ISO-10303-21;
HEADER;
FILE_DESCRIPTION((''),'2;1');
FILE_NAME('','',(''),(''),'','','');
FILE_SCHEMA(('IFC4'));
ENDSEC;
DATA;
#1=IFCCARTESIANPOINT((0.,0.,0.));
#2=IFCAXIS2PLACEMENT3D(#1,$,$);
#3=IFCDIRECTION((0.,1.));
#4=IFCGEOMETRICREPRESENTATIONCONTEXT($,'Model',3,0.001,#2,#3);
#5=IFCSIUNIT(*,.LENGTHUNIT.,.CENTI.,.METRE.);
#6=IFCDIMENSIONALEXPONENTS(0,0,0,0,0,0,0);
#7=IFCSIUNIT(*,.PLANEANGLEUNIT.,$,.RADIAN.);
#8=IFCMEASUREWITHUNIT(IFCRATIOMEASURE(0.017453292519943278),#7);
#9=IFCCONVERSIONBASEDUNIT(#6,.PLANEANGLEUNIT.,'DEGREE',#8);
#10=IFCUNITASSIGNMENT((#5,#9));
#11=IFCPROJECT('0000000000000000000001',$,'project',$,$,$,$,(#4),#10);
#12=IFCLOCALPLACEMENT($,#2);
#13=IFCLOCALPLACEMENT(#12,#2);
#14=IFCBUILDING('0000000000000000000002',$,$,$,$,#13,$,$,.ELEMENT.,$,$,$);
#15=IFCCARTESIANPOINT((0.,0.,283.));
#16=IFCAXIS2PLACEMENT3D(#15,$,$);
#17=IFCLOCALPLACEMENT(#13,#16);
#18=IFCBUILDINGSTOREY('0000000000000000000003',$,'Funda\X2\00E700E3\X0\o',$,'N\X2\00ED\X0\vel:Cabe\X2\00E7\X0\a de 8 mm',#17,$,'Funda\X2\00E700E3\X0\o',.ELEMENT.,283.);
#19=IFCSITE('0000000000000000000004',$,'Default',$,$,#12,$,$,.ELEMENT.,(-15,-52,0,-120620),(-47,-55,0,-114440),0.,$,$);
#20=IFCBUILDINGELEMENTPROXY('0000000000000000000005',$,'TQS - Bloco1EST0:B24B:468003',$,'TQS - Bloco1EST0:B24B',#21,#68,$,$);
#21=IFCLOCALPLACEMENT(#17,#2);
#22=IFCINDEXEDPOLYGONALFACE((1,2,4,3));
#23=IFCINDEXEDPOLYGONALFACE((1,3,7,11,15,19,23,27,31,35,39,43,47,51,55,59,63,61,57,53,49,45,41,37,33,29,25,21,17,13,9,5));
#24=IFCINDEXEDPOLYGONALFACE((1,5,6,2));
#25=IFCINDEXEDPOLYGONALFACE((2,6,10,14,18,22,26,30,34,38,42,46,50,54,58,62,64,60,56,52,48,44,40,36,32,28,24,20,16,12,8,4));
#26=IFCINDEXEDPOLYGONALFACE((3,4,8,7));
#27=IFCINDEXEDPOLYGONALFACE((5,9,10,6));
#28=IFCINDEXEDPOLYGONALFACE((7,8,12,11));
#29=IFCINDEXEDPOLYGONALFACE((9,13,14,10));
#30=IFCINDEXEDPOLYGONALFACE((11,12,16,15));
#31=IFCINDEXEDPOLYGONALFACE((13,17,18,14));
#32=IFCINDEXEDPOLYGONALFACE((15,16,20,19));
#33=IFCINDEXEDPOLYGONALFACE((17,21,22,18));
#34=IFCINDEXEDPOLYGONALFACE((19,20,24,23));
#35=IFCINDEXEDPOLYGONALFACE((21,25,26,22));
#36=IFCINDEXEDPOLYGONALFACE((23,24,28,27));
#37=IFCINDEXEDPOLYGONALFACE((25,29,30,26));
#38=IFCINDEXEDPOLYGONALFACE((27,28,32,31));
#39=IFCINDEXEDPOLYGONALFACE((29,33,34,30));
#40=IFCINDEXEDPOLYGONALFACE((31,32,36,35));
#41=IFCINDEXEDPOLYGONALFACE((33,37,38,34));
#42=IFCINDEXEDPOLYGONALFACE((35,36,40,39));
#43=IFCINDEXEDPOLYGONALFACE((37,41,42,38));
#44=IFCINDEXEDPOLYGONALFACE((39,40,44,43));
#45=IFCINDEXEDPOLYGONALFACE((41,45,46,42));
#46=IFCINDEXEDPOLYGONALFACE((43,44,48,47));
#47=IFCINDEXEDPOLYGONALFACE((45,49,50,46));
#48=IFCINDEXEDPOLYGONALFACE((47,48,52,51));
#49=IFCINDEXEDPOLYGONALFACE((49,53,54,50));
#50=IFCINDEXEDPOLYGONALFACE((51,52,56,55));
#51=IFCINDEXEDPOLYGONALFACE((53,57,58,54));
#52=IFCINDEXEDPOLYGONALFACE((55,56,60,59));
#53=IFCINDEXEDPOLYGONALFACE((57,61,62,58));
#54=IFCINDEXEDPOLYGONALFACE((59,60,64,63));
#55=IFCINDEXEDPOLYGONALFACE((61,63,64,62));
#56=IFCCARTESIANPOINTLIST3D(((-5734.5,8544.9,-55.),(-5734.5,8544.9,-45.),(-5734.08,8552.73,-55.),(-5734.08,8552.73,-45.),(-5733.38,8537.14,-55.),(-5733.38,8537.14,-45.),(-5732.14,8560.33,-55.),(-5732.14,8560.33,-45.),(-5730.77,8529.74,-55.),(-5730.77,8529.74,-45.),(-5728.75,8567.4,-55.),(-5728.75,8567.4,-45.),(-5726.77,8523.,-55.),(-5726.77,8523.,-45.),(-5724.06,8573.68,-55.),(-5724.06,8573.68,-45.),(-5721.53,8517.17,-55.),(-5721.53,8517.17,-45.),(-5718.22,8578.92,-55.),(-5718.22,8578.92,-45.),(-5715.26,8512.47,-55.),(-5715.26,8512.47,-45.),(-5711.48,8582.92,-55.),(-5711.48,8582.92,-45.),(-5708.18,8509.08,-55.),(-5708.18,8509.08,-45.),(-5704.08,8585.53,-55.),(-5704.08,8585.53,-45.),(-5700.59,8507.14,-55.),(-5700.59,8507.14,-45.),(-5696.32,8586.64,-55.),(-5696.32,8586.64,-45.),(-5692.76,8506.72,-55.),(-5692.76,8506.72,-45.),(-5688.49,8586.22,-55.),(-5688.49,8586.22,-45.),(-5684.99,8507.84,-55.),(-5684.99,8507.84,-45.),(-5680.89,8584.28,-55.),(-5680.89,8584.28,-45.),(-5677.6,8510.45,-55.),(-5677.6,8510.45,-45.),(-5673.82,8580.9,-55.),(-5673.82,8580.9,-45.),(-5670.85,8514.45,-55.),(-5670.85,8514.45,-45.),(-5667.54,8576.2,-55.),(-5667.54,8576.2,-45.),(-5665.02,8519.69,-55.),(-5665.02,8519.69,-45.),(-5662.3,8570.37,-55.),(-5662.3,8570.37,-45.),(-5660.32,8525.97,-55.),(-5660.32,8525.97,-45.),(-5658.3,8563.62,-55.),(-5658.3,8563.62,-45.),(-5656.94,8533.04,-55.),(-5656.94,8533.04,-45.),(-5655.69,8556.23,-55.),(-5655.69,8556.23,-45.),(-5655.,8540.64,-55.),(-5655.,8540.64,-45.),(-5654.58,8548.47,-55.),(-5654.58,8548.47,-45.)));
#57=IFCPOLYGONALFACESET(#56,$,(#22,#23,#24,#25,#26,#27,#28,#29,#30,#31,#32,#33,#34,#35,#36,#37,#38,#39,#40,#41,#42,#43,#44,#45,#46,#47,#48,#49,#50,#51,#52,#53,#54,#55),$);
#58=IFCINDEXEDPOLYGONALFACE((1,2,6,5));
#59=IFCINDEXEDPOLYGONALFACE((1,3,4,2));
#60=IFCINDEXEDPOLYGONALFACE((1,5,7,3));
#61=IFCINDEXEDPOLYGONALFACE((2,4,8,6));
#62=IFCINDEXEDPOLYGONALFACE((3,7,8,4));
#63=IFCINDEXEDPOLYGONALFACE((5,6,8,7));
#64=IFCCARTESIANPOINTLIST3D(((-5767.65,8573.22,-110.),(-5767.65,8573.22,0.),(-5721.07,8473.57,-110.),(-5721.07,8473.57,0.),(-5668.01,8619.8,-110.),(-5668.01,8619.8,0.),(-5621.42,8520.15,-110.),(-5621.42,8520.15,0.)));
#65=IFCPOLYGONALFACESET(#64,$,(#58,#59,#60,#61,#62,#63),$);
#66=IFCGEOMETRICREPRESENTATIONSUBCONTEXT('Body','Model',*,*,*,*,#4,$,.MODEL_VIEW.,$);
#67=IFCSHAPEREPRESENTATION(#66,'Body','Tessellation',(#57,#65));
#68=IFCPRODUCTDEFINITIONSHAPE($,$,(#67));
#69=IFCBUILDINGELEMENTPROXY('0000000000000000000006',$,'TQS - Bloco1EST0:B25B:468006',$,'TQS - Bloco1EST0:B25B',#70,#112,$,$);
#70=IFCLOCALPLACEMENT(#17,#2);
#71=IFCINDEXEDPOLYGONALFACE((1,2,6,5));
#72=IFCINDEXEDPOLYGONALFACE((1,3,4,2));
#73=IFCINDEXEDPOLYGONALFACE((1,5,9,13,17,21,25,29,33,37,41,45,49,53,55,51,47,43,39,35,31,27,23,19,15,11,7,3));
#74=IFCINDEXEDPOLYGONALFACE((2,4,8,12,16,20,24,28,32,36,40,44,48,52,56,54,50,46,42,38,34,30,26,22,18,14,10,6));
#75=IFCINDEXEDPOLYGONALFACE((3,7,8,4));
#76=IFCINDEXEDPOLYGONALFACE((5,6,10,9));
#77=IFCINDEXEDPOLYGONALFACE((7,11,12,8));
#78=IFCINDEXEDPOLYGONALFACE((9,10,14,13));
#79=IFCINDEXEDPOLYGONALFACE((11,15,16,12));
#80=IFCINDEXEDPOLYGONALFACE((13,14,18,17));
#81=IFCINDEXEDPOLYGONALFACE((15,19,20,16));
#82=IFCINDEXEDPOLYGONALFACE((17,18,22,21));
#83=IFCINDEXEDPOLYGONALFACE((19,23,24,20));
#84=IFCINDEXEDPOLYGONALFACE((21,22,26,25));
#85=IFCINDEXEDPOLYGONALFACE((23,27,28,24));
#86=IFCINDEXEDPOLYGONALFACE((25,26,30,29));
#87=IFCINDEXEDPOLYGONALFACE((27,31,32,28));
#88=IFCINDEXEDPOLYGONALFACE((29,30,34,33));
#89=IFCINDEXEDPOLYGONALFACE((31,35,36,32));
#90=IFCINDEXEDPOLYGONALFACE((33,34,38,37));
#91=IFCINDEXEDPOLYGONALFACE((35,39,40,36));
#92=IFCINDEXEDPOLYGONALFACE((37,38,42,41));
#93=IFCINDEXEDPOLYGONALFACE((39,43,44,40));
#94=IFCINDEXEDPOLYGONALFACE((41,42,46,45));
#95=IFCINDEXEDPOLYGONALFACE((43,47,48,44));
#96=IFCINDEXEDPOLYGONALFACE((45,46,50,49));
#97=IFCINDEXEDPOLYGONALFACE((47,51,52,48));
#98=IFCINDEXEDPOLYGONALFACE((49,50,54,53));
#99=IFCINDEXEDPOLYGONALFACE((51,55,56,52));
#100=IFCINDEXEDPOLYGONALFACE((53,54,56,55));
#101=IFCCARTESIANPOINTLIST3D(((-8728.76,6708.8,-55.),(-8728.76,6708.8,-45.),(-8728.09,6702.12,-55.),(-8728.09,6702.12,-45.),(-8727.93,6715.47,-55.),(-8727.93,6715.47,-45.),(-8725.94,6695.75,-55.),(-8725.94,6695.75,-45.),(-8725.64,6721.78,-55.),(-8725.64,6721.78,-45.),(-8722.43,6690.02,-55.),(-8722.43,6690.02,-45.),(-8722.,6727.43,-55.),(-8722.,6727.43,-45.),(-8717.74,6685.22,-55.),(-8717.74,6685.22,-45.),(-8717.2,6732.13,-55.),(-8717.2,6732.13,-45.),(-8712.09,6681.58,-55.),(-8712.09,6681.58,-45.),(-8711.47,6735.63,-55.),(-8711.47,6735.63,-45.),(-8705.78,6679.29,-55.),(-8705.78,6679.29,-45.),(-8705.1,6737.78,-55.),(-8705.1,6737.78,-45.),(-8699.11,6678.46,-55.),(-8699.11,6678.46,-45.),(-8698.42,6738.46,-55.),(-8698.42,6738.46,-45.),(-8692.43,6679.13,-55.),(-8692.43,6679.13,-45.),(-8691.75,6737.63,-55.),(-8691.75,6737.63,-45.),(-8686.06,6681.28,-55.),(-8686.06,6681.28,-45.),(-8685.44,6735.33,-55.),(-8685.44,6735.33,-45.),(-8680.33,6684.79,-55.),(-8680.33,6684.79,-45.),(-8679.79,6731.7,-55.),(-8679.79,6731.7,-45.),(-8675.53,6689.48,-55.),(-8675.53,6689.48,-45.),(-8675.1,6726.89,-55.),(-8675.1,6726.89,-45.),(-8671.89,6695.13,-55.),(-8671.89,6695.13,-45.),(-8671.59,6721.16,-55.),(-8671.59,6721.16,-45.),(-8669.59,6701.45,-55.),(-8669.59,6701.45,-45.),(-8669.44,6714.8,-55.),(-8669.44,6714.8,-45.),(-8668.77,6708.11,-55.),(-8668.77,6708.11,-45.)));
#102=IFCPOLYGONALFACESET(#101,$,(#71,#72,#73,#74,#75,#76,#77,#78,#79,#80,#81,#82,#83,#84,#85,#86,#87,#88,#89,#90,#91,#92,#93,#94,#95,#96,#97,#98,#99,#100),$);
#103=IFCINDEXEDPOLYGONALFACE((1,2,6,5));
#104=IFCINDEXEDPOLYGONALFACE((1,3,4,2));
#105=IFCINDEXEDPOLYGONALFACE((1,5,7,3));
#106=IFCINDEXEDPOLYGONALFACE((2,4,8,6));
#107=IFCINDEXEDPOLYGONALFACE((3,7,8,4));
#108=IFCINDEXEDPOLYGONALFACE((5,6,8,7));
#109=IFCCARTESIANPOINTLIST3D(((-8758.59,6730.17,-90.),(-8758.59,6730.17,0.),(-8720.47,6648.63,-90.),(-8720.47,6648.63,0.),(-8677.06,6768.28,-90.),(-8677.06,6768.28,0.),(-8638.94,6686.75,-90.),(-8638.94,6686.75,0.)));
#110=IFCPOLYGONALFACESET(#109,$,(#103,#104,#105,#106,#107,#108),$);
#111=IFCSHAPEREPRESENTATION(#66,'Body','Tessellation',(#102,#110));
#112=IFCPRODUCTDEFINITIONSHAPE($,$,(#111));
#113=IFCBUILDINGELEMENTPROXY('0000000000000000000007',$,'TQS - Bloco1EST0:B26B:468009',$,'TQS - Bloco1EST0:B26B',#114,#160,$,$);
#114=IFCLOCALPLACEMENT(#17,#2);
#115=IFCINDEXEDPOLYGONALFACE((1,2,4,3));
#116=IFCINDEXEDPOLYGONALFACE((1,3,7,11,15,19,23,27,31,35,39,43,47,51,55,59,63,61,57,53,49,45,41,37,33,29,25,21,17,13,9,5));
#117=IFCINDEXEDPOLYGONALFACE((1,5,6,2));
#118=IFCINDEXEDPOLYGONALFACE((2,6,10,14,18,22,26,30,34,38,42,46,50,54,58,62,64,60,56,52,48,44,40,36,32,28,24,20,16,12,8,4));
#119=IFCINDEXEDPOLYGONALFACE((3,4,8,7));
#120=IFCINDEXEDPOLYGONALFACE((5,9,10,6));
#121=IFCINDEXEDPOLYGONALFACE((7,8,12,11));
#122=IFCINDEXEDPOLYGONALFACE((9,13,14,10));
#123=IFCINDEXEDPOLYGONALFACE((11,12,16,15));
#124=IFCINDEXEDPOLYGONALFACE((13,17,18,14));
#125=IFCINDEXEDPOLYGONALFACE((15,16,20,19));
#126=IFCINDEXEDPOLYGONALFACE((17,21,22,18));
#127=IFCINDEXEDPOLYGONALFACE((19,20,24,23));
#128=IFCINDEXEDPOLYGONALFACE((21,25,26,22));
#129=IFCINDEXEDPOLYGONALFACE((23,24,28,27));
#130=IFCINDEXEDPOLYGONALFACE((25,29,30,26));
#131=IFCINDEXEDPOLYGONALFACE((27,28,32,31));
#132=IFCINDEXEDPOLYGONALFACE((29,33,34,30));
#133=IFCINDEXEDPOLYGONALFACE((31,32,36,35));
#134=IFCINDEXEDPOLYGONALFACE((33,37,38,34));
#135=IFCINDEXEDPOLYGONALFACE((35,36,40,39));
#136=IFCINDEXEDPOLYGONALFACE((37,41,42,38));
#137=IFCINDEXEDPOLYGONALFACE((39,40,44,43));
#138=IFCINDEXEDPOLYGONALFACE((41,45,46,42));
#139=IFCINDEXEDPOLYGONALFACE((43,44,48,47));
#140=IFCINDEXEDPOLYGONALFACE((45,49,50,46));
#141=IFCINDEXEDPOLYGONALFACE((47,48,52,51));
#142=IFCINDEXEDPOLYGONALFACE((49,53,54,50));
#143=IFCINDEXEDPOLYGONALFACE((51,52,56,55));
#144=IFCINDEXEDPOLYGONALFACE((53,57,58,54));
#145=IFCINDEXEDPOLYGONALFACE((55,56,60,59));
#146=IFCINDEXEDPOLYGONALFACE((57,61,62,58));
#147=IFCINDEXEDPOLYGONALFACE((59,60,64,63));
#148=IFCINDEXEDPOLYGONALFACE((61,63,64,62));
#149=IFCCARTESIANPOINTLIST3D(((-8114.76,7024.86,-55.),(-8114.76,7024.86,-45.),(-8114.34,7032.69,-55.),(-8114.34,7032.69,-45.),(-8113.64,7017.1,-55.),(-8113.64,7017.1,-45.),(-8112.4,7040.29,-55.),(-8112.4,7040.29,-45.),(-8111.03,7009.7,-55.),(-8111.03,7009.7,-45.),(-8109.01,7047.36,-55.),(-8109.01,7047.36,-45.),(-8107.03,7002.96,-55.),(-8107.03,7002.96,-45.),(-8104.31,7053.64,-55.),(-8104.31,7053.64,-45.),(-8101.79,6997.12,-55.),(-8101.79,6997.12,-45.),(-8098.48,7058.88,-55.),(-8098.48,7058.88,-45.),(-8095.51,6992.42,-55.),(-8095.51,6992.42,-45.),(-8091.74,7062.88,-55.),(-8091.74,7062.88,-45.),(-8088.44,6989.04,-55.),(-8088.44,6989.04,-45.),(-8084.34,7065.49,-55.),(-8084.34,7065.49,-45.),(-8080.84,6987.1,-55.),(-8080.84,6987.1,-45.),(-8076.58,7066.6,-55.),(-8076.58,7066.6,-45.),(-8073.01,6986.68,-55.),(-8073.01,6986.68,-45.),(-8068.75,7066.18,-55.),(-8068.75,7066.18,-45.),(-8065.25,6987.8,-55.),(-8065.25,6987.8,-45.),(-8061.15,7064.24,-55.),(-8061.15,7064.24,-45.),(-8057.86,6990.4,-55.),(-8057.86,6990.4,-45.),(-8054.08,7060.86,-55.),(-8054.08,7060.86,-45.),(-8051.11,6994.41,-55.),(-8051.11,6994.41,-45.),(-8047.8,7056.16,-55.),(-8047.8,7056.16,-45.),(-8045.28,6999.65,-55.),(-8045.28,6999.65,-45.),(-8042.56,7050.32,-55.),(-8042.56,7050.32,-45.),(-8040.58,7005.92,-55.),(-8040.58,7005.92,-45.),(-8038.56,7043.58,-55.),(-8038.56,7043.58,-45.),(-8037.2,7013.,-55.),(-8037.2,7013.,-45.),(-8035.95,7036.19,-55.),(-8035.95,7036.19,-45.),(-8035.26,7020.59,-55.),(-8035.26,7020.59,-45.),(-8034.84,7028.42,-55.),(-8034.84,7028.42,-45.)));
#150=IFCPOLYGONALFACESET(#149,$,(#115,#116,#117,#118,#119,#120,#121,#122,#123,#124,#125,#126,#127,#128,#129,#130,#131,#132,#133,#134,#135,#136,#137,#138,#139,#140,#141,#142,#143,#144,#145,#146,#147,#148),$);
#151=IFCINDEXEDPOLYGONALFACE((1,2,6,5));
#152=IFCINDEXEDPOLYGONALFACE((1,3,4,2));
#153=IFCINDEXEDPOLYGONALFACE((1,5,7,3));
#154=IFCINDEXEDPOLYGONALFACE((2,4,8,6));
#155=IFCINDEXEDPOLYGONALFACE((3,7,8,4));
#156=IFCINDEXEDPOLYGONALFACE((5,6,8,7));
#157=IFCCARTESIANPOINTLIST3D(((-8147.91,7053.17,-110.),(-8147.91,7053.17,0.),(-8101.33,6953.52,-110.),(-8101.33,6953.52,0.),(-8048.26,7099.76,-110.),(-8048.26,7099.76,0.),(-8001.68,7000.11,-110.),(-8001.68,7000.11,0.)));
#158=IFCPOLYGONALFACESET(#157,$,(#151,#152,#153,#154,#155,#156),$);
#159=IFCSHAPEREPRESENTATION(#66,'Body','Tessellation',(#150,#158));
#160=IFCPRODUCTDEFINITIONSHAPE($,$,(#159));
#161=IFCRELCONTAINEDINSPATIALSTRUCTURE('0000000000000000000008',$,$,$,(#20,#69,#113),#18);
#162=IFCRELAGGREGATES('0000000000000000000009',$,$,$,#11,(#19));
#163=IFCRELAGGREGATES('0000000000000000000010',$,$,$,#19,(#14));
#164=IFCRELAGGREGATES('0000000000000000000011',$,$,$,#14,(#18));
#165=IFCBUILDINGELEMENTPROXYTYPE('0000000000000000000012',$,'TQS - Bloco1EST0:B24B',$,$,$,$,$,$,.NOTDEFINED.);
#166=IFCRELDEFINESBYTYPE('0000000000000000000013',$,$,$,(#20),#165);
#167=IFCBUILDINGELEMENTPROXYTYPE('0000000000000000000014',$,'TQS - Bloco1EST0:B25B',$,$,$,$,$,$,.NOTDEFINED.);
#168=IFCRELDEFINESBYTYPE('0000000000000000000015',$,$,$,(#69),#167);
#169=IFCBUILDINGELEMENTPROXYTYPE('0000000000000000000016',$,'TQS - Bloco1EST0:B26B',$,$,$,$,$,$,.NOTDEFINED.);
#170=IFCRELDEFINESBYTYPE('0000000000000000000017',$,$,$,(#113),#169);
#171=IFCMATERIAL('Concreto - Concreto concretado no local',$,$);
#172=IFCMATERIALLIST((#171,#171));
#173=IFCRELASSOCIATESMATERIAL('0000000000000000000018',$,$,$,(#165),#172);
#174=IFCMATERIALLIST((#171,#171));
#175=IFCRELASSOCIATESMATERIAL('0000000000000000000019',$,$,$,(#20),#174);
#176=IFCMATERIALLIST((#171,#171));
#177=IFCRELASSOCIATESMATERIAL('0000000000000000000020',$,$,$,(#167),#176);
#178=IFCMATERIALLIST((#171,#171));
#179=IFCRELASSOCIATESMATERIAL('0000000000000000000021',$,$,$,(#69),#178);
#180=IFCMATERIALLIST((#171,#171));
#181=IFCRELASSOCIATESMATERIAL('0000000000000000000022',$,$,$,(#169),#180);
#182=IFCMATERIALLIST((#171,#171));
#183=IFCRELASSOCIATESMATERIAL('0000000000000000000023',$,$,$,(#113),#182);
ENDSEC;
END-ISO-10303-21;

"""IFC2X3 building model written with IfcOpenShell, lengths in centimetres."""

from ifc_helpers import new_model, entity, si_unit, converted_unit, direction, frame, frame_2d, origin, origin_2d_with_axis, place, context, subcontext, project, spatial, rectangle, circle, extrude, source, transform, mapped, material, material_list, type_object, type_shapes, element, save


model = new_model("IFC2X3")

# Units and contexts
model_context = context("Model", 3, precision=0.001, world=origin(), true_north=direction((0.0, 1.0)))
body_context = subcontext(model_context, "Body", "Model", "MODEL_VIEW")
ifc_project = project(units=[si_unit("LENGTHUNIT", "METRE", prefix="CENTI"), converted_unit("PLANEANGLEUNIT", "DEGREE", entity("IfcRatioMeasure", 0.017453292519943278), si_unit("PLANEANGLEUNIT", "RADIAN"), dimensions=[0, 0, 0, 0, 0, 0, 0])], contexts=[model_context])

# Site, building, storey
site_placement = place(None, origin())
site = spatial("IfcSite", under=ifc_project, at=site_placement, Name="Default", CompositionType="ELEMENT", RefLatitude=(-15, -52, 0, -120620), RefLongitude=(-47, -55, 0, -114440), RefElevation=0.0)
building_placement = place(site_placement, origin())
building = spatial("IfcBuilding", under=site, at=building_placement, CompositionType="ELEMENT")
storey_placement = place(building_placement, frame((0.0, 0.0, 283.0)))
storey = spatial("IfcBuildingStorey", under=building, at=storey_placement, Name="Fundação", ObjectType="Nível:Cabeça de 8 mm", LongName="Fundação", CompositionType="ELEMENT", Elevation=283.0)

# Building element proxies
ifc_material_1 = material(Name="Concreto - Concreto concretado no local")
ifc_material_list_1 = material_list([ifc_material_1, ifc_material_1])
ifc_material_list_2 = material_list([ifc_material_1, ifc_material_1])
building_element_proxy_type_1 = type_object("IfcBuildingElementProxyType", Name="TQS - Bloco1EST0:B24B", PredefinedType="NOTDEFINED", material=ifc_material_list_2)
shared_shape_1 = source(origin(), body_context, "Body", "SweptSolid", [
    extrude(circle(Radius=40.0, at=frame_2d((0.0, 0.0), x_axis=(1.0, 0.0))), frame((0.0, 0.0, -55.0)), (0.0, 0.0, 1.0), 10.0),
    extrude(rectangle(XDim=110.0, YDim=110.0, at=origin_2d_with_axis()), frame((0.0, 0.0, -110.0), z_axis=(0.0, 0.0, 1.0), x_axis=(-1.0, 0.0, 0.0)), (0.0, 0.0, 1.0), 110.0),
])
type_shapes(building_element_proxy_type_1, [shared_shape_1])
proxy_1_placement = place(storey_placement, frame((-5694.54, 8546.68, 0.0), z_axis=(0.0, 0.0, 1.0), x_axis=(0.905902, 0.423488, 0.0)))
element("IfcBuildingElementProxy", 1, at=proxy_1_placement, inside=storey, type_object=building_element_proxy_type_1, material=ifc_material_list_1, Name="TQS - Bloco1EST0:B24B:468003", ObjectType="TQS - Bloco1EST0:B24B", context=body_context, shape_type="MappedRepresentation", body=[
    mapped(shared_shape_1, transform((0.0, 0.0, 0.0), scale=1.0)),
])
ifc_material_list_3 = material_list([ifc_material_1, ifc_material_1])
ifc_material_list_4 = material_list([ifc_material_1, ifc_material_1])
building_element_proxy_type_2 = type_object("IfcBuildingElementProxyType", Name="TQS - Bloco1EST0:B25B", PredefinedType="NOTDEFINED", material=ifc_material_list_4)
shared_shape_2 = source(origin(), body_context, "Body", "SweptSolid", [
    extrude(circle(Radius=30.0, at=frame_2d((0.0, 0.0), x_axis=(1.0, 0.0))), frame((0.0, 0.0, -55.0)), (0.0, 0.0, 1.0), 10.0),
    extrude(rectangle(XDim=90.0, YDim=90.0, at=origin_2d_with_axis()), frame((0.0, 0.0, -90.0), z_axis=(0.0, 0.0, 1.0), x_axis=(-1.0, 0.0, 0.0)), (0.0, 0.0, 1.0), 90.0),
])
type_shapes(building_element_proxy_type_2, [shared_shape_2])
proxy_2_placement = place(storey_placement, frame((-8698.76, 6708.46, 0.0), z_axis=(0.0, 0.0, 1.0), x_axis=(0.905902, 0.423488, 0.0)))
element("IfcBuildingElementProxy", 2, at=proxy_2_placement, inside=storey, type_object=building_element_proxy_type_2, material=ifc_material_list_3, Name="TQS - Bloco1EST0:B25B:468006", ObjectType="TQS - Bloco1EST0:B25B", context=body_context, shape_type="MappedRepresentation", body=[
    mapped(shared_shape_2, transform((0.0, 0.0, 0.0), scale=1.0)),
])
ifc_material_list_5 = material_list([ifc_material_1, ifc_material_1])
ifc_material_list_6 = material_list([ifc_material_1, ifc_material_1])
building_element_proxy_type_3 = type_object("IfcBuildingElementProxyType", Name="TQS - Bloco1EST0:B26B", PredefinedType="NOTDEFINED", material=ifc_material_list_6)
shared_shape_3 = source(origin(), body_context, "Body", "SweptSolid", [
    extrude(circle(Radius=40.0, at=frame_2d((0.0, 0.0), x_axis=(1.0, 0.0))), frame((0.0, 0.0, -55.0)), (0.0, 0.0, 1.0), 10.0),
    extrude(rectangle(XDim=110.0, YDim=110.0, at=origin_2d_with_axis()), frame((0.0, 0.0, -110.0), z_axis=(0.0, 0.0, 1.0), x_axis=(-1.0, 0.0, 0.0)), (0.0, 0.0, 1.0), 110.0),
])
type_shapes(building_element_proxy_type_3, [shared_shape_3])
proxy_3_placement = place(storey_placement, frame((-8074.8, 7026.64, 0.0), z_axis=(0.0, 0.0, 1.0), x_axis=(0.905902, 0.423488, 0.0)))
element("IfcBuildingElementProxy", 3, at=proxy_3_placement, inside=storey, type_object=building_element_proxy_type_3, material=ifc_material_list_5, Name="TQS - Bloco1EST0:B26B:468009", ObjectType="TQS - Bloco1EST0:B26B", context=body_context, shape_type="MappedRepresentation", body=[
    mapped(shared_shape_3, transform((0.0, 0.0, 0.0), scale=1.0)),
])

save(model, "model.ifc")
